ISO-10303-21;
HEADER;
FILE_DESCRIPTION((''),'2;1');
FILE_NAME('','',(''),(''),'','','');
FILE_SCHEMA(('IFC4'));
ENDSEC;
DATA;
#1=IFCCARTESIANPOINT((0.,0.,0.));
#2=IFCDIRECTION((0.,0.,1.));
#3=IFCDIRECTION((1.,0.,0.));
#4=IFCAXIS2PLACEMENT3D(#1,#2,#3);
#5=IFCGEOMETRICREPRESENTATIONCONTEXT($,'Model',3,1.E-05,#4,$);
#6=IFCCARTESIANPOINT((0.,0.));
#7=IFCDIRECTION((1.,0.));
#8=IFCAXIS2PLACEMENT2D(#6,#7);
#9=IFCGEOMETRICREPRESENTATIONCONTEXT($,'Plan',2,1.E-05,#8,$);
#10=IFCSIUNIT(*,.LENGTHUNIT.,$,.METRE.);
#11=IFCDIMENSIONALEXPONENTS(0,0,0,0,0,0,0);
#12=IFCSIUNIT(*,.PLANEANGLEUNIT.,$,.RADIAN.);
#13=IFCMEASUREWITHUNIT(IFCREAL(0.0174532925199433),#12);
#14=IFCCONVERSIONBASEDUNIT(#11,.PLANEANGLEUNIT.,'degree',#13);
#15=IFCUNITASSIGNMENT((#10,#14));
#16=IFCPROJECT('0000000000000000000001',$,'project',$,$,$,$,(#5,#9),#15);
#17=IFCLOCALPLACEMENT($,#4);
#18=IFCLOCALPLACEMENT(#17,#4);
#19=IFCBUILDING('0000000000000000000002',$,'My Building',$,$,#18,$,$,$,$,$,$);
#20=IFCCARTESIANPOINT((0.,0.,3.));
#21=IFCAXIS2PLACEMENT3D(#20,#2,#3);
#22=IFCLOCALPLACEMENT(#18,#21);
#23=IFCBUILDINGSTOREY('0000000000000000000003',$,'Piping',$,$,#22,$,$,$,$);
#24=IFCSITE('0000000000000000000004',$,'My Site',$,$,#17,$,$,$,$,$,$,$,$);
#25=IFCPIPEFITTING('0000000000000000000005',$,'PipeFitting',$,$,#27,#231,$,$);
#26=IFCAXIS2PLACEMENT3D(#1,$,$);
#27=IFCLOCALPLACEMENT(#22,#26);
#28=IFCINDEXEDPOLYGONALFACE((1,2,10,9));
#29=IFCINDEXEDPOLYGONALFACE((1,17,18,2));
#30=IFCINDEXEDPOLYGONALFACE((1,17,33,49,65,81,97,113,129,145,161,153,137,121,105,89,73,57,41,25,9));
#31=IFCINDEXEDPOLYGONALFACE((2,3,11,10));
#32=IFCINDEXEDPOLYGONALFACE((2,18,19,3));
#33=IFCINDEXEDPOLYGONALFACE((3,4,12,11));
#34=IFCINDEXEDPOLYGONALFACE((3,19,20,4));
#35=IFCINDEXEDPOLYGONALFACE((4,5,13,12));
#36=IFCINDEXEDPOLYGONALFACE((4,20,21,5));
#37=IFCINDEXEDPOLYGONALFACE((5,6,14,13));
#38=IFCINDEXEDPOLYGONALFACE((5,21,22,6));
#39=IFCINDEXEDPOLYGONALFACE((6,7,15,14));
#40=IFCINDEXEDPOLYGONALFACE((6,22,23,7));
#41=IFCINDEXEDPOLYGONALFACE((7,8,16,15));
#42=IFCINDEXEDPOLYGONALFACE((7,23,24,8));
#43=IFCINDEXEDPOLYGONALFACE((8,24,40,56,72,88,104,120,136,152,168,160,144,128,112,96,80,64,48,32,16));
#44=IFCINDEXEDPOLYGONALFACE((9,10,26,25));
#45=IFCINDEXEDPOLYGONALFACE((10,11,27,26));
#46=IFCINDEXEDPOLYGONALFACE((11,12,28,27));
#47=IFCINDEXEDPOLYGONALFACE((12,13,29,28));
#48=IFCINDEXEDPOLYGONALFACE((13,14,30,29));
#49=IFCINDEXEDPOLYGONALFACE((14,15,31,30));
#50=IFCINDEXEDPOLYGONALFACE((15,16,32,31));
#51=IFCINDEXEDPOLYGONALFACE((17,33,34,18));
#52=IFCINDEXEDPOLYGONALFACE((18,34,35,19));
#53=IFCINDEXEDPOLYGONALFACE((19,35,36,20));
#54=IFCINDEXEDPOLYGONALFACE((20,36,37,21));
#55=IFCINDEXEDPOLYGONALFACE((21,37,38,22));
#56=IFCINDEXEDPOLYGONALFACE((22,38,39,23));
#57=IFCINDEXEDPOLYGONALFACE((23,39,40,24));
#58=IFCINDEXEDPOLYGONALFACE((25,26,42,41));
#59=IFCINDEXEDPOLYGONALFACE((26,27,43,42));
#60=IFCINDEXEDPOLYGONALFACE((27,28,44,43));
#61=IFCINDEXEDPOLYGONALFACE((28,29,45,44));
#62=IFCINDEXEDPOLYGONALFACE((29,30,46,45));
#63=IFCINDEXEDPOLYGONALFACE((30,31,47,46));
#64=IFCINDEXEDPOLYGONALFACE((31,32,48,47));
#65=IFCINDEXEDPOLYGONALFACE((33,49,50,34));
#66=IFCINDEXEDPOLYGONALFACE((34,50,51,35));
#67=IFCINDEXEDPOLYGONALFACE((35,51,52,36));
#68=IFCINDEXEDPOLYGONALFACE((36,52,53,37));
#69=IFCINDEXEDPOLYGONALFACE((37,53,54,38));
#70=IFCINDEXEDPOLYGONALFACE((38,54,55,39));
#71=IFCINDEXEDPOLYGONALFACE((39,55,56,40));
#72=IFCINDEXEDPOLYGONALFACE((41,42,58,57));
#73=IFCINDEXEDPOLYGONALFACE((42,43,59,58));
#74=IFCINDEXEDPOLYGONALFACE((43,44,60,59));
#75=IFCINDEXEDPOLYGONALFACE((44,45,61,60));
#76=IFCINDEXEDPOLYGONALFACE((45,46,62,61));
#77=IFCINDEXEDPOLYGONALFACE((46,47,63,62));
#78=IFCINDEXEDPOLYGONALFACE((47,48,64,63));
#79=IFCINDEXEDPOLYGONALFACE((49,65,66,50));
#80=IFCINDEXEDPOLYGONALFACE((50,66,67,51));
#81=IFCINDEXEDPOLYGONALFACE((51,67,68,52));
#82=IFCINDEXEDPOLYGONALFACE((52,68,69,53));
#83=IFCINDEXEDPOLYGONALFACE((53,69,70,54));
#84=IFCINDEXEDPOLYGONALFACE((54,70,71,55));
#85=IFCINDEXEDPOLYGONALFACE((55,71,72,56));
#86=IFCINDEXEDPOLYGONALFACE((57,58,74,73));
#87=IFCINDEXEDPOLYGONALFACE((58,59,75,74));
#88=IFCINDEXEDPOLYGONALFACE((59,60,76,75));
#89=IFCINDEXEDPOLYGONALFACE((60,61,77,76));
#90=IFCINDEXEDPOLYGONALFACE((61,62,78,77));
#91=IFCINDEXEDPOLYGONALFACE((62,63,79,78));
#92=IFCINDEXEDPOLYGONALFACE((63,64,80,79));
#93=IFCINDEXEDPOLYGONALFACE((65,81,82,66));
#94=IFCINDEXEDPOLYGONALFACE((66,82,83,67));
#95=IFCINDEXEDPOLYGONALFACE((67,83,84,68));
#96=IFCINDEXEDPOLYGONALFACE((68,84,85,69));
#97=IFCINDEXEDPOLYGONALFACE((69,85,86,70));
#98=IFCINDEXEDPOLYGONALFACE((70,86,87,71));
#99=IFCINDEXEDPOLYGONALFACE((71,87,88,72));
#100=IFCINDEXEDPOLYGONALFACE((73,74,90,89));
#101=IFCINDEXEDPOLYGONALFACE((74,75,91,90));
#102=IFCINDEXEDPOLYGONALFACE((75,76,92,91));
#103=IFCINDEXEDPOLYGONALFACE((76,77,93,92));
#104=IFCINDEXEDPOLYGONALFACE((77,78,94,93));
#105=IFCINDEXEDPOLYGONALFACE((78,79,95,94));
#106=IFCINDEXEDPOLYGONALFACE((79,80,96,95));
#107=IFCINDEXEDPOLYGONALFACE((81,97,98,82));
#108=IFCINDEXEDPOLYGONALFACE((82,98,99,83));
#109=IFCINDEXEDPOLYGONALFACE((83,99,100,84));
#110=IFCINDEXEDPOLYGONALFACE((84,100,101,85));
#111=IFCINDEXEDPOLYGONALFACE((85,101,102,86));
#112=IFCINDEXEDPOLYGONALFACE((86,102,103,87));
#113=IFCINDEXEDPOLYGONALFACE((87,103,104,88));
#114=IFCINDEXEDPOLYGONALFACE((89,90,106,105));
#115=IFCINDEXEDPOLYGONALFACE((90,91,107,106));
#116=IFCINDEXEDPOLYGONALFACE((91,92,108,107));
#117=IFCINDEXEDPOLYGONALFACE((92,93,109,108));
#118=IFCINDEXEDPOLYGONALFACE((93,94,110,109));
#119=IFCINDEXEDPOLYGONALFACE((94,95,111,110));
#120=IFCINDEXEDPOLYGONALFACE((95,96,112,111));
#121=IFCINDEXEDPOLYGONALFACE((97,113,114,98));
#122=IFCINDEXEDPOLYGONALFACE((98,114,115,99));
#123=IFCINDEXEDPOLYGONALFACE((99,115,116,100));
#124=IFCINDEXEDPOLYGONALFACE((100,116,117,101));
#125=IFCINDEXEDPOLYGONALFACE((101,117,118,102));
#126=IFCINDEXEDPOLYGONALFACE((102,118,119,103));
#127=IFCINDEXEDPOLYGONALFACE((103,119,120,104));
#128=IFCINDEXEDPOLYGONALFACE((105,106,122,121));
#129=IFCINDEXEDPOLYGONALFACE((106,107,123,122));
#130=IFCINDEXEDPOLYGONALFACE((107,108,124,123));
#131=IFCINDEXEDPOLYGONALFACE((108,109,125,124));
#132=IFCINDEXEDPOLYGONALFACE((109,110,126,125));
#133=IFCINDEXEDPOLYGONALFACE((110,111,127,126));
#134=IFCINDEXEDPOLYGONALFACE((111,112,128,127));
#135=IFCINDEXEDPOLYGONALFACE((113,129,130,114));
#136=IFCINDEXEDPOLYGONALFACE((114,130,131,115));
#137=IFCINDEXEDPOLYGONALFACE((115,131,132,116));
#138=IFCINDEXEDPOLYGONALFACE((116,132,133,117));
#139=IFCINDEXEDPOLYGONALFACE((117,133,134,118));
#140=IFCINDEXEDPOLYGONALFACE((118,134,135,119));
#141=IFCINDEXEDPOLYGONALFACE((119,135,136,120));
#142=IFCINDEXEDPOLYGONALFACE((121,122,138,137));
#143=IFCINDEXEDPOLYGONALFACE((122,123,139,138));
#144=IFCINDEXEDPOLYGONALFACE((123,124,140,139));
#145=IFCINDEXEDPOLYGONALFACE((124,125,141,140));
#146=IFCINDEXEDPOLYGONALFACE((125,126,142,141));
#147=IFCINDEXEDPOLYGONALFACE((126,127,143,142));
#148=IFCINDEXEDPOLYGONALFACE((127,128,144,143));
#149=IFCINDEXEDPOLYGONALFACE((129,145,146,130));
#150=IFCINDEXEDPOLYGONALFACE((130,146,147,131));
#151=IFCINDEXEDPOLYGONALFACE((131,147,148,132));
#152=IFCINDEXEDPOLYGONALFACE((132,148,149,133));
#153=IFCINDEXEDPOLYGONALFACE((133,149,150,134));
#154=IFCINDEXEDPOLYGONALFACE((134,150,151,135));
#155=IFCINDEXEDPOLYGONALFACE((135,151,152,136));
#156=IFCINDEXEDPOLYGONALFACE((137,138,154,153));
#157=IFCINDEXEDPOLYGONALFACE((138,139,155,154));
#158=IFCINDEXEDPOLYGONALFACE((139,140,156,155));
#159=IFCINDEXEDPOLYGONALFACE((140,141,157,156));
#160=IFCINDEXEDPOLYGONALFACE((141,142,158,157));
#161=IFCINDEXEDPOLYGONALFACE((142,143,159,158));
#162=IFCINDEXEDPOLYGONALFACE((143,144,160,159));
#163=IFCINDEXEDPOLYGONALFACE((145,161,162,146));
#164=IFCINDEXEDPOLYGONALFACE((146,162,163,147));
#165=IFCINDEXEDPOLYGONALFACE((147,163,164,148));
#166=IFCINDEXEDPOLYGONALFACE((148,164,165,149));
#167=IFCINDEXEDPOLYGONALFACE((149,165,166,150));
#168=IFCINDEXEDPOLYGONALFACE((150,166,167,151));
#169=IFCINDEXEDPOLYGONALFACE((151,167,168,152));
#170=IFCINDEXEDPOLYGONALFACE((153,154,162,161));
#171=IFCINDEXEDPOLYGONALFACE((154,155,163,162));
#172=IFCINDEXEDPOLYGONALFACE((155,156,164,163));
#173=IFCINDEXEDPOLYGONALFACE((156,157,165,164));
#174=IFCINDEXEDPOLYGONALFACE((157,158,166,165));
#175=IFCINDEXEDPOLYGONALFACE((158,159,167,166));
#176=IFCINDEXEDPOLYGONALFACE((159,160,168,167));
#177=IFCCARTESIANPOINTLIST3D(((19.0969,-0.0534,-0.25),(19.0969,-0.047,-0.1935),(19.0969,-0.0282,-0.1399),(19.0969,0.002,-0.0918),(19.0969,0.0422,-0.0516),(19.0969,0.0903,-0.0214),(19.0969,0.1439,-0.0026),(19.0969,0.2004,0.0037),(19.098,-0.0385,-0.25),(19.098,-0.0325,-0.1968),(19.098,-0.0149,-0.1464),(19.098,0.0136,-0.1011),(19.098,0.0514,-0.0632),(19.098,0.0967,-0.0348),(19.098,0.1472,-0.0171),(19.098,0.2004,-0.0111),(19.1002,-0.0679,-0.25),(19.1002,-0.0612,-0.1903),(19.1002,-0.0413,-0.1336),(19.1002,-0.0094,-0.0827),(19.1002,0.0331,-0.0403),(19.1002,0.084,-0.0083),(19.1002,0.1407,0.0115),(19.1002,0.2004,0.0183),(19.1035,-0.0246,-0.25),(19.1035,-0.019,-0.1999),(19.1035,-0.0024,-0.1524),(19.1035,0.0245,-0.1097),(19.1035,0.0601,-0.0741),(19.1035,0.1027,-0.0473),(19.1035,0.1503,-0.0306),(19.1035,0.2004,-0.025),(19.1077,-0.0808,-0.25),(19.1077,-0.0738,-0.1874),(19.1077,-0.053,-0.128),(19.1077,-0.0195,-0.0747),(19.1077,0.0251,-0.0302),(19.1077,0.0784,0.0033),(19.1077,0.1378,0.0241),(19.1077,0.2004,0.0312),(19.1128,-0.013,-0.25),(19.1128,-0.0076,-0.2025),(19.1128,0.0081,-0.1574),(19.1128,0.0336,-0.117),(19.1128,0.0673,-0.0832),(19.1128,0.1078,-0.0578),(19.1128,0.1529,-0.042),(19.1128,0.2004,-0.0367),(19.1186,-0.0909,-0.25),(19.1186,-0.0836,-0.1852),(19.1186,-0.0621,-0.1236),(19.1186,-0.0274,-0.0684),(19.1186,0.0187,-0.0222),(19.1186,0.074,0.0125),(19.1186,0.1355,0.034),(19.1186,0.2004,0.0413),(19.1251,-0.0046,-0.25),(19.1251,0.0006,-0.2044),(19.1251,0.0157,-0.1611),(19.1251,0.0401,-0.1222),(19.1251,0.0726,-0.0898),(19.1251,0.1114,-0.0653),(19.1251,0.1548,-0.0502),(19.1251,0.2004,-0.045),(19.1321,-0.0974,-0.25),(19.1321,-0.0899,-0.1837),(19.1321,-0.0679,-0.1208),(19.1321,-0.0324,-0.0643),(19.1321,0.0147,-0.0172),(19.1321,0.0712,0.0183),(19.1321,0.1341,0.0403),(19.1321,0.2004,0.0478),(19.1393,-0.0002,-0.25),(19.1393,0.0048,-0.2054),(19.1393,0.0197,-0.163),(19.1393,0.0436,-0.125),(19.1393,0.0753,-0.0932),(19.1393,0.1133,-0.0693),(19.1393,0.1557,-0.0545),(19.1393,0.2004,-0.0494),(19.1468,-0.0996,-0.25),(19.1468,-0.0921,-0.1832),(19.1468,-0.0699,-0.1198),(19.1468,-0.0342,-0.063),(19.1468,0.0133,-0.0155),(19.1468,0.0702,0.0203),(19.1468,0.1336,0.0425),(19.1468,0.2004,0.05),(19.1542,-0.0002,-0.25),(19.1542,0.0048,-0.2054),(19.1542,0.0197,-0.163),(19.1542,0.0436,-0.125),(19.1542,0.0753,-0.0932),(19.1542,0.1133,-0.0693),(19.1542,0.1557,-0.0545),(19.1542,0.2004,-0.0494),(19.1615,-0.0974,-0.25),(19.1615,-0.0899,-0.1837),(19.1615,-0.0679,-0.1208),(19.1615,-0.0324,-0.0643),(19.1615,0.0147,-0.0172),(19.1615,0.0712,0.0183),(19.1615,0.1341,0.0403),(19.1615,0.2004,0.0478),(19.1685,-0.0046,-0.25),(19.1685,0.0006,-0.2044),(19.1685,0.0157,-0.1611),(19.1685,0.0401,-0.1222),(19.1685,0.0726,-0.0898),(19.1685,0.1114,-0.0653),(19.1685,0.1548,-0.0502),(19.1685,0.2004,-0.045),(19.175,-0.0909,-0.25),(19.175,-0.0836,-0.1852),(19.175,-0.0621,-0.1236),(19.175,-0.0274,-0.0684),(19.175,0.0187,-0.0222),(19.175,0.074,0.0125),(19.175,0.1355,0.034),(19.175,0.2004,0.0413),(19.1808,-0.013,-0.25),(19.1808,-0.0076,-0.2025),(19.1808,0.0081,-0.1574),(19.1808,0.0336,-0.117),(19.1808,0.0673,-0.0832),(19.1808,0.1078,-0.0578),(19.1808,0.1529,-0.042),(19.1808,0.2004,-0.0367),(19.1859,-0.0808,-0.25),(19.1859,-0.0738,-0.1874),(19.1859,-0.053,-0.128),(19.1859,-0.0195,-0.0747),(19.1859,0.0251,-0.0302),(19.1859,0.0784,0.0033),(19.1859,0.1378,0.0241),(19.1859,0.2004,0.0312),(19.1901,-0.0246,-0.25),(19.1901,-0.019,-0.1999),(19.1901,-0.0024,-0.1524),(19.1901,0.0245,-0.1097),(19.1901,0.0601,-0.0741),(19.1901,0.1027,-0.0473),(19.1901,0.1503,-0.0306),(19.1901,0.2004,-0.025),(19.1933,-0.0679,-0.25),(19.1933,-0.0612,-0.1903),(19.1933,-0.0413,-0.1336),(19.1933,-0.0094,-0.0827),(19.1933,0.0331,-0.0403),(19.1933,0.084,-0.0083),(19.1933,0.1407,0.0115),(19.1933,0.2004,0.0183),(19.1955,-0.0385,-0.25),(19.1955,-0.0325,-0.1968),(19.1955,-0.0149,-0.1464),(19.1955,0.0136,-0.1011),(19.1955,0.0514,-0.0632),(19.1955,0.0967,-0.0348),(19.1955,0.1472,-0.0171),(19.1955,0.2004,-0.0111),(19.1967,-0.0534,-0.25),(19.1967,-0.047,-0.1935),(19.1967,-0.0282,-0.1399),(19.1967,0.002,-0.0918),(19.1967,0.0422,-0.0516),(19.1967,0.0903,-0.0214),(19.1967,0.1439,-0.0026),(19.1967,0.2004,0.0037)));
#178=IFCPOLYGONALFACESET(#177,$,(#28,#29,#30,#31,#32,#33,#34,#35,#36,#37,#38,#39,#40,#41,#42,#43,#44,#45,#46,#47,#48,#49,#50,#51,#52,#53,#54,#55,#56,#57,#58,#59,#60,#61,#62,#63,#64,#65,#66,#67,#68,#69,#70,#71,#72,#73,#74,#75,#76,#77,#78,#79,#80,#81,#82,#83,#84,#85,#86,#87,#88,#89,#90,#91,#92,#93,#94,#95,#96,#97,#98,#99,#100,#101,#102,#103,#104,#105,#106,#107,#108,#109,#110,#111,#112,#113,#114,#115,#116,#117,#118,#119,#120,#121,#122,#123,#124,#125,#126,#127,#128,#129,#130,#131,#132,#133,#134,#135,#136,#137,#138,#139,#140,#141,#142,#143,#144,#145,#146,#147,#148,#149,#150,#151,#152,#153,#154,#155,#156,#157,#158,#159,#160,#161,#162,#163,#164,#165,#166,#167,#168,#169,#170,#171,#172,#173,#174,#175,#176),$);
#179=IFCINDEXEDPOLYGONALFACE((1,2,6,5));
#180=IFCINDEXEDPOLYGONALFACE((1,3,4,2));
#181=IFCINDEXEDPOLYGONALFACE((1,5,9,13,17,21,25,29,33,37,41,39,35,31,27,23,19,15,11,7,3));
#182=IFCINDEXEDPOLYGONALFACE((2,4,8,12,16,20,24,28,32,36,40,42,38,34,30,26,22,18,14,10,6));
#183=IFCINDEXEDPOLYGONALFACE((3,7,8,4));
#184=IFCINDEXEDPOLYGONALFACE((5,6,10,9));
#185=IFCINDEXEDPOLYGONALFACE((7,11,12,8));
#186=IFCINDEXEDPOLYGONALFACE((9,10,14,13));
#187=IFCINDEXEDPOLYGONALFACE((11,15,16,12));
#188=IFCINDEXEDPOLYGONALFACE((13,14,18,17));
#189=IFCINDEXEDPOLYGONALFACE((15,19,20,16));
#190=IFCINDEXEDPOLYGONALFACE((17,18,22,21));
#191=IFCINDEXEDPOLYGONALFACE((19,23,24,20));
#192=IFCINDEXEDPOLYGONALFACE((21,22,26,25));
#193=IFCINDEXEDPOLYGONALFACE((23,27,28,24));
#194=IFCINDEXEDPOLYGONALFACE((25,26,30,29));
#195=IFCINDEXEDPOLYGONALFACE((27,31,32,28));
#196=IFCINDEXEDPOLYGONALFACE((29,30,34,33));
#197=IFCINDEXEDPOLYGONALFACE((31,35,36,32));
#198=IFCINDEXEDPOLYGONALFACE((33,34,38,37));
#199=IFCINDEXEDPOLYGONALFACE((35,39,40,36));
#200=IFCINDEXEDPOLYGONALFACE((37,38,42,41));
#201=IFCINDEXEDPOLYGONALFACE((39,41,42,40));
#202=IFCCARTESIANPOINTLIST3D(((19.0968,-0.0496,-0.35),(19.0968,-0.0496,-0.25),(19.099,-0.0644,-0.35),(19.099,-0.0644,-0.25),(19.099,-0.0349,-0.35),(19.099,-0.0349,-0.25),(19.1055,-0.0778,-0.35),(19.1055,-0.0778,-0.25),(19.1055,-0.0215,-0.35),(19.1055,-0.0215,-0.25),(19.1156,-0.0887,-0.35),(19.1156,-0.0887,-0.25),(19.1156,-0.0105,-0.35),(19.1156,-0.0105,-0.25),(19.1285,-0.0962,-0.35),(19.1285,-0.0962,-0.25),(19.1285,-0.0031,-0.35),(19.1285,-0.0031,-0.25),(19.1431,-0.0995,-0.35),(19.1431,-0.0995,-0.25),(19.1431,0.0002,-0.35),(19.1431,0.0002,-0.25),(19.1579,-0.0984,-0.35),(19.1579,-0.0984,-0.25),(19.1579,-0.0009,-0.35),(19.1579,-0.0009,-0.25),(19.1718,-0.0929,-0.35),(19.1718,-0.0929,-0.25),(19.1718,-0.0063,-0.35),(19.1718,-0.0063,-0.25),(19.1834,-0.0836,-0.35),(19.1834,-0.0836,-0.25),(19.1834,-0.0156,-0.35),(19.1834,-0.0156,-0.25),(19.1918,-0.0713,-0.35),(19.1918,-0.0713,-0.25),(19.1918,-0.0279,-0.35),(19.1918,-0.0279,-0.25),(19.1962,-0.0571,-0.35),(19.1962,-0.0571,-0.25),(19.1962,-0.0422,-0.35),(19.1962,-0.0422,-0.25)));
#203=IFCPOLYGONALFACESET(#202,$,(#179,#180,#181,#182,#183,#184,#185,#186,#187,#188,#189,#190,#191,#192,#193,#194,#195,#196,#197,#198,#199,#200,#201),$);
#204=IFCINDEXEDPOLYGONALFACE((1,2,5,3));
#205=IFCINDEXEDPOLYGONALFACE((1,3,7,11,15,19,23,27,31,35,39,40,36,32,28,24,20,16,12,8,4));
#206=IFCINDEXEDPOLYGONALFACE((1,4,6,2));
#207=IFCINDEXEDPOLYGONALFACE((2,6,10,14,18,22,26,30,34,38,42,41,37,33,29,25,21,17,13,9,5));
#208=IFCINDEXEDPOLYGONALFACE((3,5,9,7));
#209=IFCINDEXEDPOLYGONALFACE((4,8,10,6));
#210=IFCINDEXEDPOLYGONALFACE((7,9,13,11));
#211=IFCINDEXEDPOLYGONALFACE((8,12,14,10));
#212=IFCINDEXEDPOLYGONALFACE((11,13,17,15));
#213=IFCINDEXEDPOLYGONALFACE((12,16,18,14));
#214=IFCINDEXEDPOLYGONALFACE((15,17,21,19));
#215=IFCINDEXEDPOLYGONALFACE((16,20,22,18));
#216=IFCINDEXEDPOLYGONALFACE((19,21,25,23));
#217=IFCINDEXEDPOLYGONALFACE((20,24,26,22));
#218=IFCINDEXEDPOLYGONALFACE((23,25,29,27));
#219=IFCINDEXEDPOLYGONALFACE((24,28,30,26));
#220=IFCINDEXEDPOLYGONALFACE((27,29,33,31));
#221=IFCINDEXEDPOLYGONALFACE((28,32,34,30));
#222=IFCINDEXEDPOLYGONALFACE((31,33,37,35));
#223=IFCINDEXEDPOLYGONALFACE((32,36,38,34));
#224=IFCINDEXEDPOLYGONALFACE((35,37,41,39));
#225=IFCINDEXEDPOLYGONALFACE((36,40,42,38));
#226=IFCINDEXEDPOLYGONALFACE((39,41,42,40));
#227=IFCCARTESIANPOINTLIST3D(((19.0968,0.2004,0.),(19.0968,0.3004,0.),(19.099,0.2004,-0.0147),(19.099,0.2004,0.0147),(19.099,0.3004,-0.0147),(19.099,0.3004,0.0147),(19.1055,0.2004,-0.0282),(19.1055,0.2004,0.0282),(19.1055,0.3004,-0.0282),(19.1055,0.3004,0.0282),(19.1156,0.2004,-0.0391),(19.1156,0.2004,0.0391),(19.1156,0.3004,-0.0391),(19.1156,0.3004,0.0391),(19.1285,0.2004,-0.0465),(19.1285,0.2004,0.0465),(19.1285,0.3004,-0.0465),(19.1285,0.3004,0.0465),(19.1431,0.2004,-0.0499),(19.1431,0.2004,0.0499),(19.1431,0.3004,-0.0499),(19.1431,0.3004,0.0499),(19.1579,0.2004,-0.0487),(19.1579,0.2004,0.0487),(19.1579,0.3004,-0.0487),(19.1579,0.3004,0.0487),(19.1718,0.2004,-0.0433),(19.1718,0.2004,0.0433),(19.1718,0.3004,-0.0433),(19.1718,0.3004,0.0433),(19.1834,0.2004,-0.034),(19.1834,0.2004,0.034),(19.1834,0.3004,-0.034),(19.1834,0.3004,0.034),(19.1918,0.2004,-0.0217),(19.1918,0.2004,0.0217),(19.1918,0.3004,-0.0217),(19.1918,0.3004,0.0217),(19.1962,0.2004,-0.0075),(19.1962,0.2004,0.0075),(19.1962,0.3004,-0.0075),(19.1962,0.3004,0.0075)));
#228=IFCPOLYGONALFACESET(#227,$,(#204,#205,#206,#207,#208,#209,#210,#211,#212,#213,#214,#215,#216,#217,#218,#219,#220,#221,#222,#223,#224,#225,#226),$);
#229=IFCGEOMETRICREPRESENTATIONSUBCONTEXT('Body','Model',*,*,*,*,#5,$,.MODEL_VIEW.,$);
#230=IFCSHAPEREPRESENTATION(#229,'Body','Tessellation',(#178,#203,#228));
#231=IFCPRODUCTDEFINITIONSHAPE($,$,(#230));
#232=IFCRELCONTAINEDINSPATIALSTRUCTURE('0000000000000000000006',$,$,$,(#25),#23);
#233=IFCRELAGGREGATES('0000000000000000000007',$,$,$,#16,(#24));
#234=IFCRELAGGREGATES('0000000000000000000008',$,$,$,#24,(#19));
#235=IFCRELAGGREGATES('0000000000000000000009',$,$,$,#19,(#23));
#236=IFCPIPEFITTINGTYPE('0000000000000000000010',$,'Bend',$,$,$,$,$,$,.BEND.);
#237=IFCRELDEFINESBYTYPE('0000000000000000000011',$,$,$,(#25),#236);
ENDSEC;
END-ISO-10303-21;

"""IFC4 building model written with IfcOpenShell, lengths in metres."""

from ifc_helpers import new_model, entity, si_unit, converted_unit, frame, origin_with_axes, origin_2d_with_axis, place, context, subcontext, project, spatial, circle, extrude, source, transform, mapped, type_object, type_shapes, element, save


model = new_model("IFC4")

# Units and contexts
model_context = context("Model", 3, precision=1e-05, world=origin_with_axes())
plan_context = context("Plan", 2, precision=1e-05, world=origin_2d_with_axis())
body_context = subcontext(model_context, "Body", "Model", "MODEL_VIEW")
ifc_project = project(units=[si_unit("LENGTHUNIT", "METRE"), converted_unit("PLANEANGLEUNIT", "degree", entity("IfcReal", 0.0174532925199433), si_unit("PLANEANGLEUNIT", "RADIAN"), dimensions=[0, 0, 0, 0, 0, 0, 0])], contexts=[model_context, plan_context])

# Site, building, storey
site_placement = place(None, origin_with_axes())
site = spatial("IfcSite", under=ifc_project, at=site_placement, Name="My Site")
building_placement = place(site_placement, origin_with_axes())
building = spatial("IfcBuilding", under=site, at=building_placement, Name="My Building")
storey_placement = place(building_placement, frame((0.0, 0.0, 3.0), z_axis=(0.0, 0.0, 1.0), x_axis=(1.0, 0.0, 0.0)))
storey = spatial("IfcBuildingStorey", under=building, at=storey_placement, Name="Piping")

# Pipe fitting
pipe_fitting_type = type_object("IfcPipeFittingType", Name="Bend", PredefinedType="BEND")
shared_shape = source(origin_with_axes(), body_context, "Body", "SolidModel", [
    entity("IfcSweptDiskSolid", entity("IfcIndexedPolyCurve", entity("IfcCartesianPointList3D", [[0.0, 0.0, -0.1], [0.0, 0.0732, -0.2768], [0.0, 0.25, -0.35]]), [entity("IfcArcIndex", [1, 2, 3])]), 0.05),
    extrude(circle(Radius=0.05), origin_with_axes(), (0.0, 0.0, -1.0), 0.1),
    extrude(circle(Radius=0.05), frame((0.0, 0.25, -0.35), z_axis=(0.0, 1.0, 0.0), x_axis=(1.0, 0.0, 0.0)), (0.0, 0.0, 1.0), 0.1),
])
type_shapes(pipe_fitting_type, [shared_shape])
for number, where, z_axis, x_axis, name in (
    (1, (19.1468, -0.0496, -0.35), (0.0, 0.0, -1.0), (-1.0, 0.0, 0.0), "PipeFitting"),
):
    element("IfcPipeFitting", number, at=place(storey_placement, frame(where, z_axis=z_axis, x_axis=x_axis)), inside=storey, type_object=pipe_fitting_type, Name=name, context=body_context, shape_type="MappedRepresentation", body=[
        mapped(shared_shape, transform((0.0, 0.0, 0.0), x_axis=(1.0, 0.0, 0.0), y_axis=(0.0, 1.0, 0.0), z_axis=(0.0, 0.0, 1.0), scale=1.0)),
    ])

save(model, "model.ifc")
